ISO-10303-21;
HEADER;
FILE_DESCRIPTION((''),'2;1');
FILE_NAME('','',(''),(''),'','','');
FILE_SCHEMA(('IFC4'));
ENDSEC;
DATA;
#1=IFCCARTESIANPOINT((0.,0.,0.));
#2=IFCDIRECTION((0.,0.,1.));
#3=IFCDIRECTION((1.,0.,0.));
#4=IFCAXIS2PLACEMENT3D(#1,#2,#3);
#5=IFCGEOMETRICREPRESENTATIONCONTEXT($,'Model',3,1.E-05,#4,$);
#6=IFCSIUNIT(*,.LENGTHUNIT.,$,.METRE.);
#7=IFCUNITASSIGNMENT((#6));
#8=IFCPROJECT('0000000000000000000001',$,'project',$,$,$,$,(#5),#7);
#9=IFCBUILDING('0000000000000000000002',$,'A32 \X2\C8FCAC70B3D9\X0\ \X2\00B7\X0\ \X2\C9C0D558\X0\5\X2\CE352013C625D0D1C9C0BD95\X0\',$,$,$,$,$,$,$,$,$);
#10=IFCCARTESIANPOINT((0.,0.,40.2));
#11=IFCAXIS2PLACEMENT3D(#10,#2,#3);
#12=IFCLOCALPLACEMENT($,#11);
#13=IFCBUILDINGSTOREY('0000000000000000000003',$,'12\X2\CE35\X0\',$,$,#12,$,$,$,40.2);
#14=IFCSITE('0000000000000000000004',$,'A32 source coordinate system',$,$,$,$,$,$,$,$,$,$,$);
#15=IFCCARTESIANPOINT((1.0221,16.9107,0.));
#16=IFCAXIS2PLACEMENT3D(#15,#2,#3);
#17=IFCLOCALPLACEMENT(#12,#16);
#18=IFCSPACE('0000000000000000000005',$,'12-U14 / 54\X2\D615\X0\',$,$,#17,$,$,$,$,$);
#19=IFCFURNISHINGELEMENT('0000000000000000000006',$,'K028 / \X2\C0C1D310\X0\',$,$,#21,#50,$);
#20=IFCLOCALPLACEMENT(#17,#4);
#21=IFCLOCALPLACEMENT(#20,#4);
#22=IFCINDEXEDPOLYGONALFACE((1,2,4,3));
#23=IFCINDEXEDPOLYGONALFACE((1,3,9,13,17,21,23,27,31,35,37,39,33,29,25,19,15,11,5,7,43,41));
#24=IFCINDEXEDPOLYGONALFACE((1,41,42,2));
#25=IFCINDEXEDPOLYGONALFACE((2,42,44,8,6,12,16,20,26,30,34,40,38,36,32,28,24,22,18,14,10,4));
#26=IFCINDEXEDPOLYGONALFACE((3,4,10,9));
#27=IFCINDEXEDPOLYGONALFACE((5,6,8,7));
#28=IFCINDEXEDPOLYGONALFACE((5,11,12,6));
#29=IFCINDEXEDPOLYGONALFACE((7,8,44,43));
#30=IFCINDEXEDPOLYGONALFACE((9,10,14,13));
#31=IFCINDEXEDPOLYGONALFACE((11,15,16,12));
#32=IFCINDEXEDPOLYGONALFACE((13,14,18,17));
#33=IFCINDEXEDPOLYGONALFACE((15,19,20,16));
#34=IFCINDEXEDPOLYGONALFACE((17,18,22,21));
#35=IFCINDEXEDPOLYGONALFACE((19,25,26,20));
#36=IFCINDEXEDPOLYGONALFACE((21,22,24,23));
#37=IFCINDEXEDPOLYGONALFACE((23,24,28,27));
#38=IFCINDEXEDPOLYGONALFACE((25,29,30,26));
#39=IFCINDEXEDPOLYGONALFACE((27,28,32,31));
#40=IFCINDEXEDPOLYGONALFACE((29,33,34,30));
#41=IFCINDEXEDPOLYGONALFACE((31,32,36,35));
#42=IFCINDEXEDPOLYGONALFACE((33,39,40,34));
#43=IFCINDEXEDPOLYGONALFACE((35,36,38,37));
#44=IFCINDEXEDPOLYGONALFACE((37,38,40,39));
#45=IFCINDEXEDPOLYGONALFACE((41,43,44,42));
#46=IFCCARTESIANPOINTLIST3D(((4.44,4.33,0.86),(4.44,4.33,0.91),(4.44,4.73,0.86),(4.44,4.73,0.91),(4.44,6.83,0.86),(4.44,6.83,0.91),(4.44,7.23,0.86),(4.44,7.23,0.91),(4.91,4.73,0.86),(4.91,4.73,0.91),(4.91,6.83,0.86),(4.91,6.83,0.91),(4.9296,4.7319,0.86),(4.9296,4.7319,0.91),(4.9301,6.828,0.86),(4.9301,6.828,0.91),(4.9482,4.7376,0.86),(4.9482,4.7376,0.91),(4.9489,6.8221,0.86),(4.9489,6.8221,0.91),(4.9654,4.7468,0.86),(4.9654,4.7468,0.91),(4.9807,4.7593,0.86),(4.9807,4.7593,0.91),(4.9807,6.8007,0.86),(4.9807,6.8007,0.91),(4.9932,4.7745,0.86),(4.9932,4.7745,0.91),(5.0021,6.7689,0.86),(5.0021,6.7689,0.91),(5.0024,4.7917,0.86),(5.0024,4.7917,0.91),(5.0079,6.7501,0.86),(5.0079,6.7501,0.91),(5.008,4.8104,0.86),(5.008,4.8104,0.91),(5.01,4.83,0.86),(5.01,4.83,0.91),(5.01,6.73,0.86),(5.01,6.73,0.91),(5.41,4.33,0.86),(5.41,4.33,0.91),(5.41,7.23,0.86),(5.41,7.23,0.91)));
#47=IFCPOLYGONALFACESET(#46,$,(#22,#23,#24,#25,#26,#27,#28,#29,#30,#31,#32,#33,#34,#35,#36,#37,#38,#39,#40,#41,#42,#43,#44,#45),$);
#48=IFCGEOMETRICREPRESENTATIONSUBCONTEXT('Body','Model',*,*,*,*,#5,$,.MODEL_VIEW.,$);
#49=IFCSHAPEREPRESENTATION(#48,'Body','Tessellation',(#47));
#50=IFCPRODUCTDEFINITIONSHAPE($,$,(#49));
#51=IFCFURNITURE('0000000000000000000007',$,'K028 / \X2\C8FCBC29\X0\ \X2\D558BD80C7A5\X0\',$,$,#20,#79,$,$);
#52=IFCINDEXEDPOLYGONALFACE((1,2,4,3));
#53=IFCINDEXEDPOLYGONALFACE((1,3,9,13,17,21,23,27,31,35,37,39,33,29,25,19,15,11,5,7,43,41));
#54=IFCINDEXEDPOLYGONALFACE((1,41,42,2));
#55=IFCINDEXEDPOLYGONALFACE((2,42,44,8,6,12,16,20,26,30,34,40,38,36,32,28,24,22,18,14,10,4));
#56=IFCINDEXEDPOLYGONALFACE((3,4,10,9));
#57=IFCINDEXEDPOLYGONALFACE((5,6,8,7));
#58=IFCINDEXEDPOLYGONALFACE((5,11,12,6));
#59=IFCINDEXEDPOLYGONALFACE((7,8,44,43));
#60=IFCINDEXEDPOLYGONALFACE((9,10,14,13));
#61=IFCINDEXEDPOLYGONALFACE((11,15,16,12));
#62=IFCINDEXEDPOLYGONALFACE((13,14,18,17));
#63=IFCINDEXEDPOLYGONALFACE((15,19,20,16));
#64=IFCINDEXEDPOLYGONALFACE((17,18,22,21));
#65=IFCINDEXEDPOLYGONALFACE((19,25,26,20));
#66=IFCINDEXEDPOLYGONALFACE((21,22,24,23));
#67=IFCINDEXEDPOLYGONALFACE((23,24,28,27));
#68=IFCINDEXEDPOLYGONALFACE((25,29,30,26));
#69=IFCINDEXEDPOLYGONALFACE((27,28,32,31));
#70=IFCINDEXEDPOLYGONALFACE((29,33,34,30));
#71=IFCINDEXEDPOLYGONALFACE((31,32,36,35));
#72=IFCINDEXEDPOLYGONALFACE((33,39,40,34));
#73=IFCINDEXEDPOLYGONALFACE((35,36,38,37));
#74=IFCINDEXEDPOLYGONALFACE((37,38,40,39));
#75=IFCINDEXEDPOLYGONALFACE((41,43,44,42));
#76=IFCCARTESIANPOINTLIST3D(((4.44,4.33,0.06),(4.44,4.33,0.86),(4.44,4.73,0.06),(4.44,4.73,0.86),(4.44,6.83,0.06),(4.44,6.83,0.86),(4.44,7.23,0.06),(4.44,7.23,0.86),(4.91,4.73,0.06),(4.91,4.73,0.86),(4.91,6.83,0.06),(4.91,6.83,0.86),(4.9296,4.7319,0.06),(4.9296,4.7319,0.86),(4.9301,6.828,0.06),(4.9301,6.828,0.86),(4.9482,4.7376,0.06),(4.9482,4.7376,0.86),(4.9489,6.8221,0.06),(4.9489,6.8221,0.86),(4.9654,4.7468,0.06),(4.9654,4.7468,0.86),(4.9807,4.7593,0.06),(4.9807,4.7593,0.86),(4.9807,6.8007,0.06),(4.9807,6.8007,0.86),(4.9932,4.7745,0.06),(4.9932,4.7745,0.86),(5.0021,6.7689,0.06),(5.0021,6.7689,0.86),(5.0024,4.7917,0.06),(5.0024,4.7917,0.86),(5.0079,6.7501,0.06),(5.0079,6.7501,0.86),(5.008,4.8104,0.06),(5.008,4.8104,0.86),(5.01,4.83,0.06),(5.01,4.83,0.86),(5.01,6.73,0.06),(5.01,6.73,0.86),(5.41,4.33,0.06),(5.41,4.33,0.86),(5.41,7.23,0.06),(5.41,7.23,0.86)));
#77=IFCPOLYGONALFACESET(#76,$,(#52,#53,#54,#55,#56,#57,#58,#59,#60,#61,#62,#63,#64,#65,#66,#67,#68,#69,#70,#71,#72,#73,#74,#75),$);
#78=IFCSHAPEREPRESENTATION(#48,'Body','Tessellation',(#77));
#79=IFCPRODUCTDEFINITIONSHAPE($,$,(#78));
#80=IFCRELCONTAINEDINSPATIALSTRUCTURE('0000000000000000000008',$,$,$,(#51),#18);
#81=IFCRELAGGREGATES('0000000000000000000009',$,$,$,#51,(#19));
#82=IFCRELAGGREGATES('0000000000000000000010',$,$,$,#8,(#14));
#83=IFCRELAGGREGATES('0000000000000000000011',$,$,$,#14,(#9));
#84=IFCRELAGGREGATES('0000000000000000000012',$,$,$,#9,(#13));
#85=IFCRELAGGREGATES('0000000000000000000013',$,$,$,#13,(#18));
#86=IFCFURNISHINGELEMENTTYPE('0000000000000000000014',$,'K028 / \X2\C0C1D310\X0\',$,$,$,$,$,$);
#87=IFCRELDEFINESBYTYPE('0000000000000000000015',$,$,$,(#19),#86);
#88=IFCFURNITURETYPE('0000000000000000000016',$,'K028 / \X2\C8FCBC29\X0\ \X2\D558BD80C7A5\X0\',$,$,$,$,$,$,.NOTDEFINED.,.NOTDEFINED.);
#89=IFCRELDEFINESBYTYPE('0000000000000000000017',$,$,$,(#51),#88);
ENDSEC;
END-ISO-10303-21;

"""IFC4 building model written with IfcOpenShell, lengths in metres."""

from ifc_helpers import new_model, si_unit, frame, origin, origin_with_axes, place, context, subcontext, project, spatial, polyline, outline, extrude, source, transform, mapped, type_object, type_shapes, element, aggregate, save


model = new_model("IFC4")

# Units and contexts
model_context = context("Model", 3, precision=1e-05, world=origin_with_axes())
body_context = subcontext(model_context, "Body", "Model", "MODEL_VIEW")
ifc_project = project(units=[si_unit("LENGTHUNIT", "METRE")], contexts=[model_context])

# Site, building, storey, space
site = spatial("IfcSite", under=ifc_project, Name="A32 source coordinate system")
building = spatial("IfcBuilding", under=site, Name="A32 주거동 · 지하5층–옥탑지붕")
storey_placement = place(None, frame((0.0, 0.0, 40.2), z_axis=(0.0, 0.0, 1.0), x_axis=(1.0, 0.0, 0.0)))
storey = spatial("IfcBuildingStorey", under=building, at=storey_placement, Name="12층", Elevation=40.2)
space_placement = place(storey_placement, frame((1.0221, 16.9107, 0.0), z_axis=(0.0, 0.0, 1.0), x_axis=(1.0, 0.0, 0.0)))
space = spatial("IfcSpace", under=storey, at=space_placement, Name="12-U14 / 54형")

# Furnishing element
furnishing_element_type_1 = type_object("IfcFurnishingElementType", Name="K028 / 상판")
shared_shape_1 = source(origin(), body_context, "Body", "SweptSolid", [
    extrude(outline(polyline([(5.41, 4.33), (4.44, 4.33), (4.44, 4.73), (4.91, 4.73), (4.9296, 4.7319), (4.9482, 4.7376), (4.9654, 4.7468), (4.9807, 4.7593), (4.9932, 4.7745), (5.0024, 4.7917), (5.008, 4.8104), (5.01, 4.83), (5.01, 6.73), (5.0079, 6.7501), (5.0021, 6.7689), (4.9807, 6.8007), (4.9489, 6.8221), (4.9301, 6.828), (4.91, 6.83), (4.44, 6.83), (4.44, 7.23), (5.41, 7.23), (5.41, 4.33)])), frame((0.0, 0.0, 0.86)), (0.0, 0.0, 1.0), 0.05),
])
type_shapes(furnishing_element_type_1, [shared_shape_1])
furniture_1_placement = place(space_placement, origin_with_axes())
furnishing_1_placement = place(furniture_1_placement, origin_with_axes())
furnishing_1 = element("IfcFurnishingElement", 1, at=furnishing_1_placement, type_object=furnishing_element_type_1, Name="K028 / 상판", context=body_context, shape_type="MappedRepresentation", body=[
    mapped(shared_shape_1, transform((0.0, 0.0, 0.0), scale=1.0)),
])

# Furniture
furniture_type_1 = type_object("IfcFurnitureType", Name="K028 / 주방 하부장", AssemblyPlace="NOTDEFINED", PredefinedType="NOTDEFINED")
shared_shape_2 = source(origin(), body_context, "Body", "SweptSolid", [
    extrude(outline(polyline([(5.41, 7.23), (5.41, 4.33), (4.44, 4.33), (4.44, 4.73), (4.91, 4.73), (4.9296, 4.7319), (4.9482, 4.7376), (4.9654, 4.7468), (4.9807, 4.7593), (4.9932, 4.7745), (5.0024, 4.7917), (5.008, 4.8104), (5.01, 4.83), (5.01, 6.73), (5.0079, 6.7501), (5.0021, 6.7689), (4.9807, 6.8007), (4.9489, 6.8221), (4.9301, 6.828), (4.91, 6.83), (4.44, 6.83), (4.44, 7.23), (5.41, 7.23)])), frame((0.0, 0.0, 0.06)), (0.0, 0.0, 1.0), 0.8),
])
type_shapes(furniture_type_1, [shared_shape_2])
furniture_1 = element("IfcFurniture", 2, at=furniture_1_placement, inside=space, type_object=furniture_type_1, Name="K028 / 주방 하부장", context=body_context, shape_type="MappedRepresentation", body=[
    mapped(shared_shape_2, transform((0.0, 0.0, 0.0), scale=1.0)),
])
aggregate(furniture_1, [furnishing_1])

save(model, "model.ifc")
